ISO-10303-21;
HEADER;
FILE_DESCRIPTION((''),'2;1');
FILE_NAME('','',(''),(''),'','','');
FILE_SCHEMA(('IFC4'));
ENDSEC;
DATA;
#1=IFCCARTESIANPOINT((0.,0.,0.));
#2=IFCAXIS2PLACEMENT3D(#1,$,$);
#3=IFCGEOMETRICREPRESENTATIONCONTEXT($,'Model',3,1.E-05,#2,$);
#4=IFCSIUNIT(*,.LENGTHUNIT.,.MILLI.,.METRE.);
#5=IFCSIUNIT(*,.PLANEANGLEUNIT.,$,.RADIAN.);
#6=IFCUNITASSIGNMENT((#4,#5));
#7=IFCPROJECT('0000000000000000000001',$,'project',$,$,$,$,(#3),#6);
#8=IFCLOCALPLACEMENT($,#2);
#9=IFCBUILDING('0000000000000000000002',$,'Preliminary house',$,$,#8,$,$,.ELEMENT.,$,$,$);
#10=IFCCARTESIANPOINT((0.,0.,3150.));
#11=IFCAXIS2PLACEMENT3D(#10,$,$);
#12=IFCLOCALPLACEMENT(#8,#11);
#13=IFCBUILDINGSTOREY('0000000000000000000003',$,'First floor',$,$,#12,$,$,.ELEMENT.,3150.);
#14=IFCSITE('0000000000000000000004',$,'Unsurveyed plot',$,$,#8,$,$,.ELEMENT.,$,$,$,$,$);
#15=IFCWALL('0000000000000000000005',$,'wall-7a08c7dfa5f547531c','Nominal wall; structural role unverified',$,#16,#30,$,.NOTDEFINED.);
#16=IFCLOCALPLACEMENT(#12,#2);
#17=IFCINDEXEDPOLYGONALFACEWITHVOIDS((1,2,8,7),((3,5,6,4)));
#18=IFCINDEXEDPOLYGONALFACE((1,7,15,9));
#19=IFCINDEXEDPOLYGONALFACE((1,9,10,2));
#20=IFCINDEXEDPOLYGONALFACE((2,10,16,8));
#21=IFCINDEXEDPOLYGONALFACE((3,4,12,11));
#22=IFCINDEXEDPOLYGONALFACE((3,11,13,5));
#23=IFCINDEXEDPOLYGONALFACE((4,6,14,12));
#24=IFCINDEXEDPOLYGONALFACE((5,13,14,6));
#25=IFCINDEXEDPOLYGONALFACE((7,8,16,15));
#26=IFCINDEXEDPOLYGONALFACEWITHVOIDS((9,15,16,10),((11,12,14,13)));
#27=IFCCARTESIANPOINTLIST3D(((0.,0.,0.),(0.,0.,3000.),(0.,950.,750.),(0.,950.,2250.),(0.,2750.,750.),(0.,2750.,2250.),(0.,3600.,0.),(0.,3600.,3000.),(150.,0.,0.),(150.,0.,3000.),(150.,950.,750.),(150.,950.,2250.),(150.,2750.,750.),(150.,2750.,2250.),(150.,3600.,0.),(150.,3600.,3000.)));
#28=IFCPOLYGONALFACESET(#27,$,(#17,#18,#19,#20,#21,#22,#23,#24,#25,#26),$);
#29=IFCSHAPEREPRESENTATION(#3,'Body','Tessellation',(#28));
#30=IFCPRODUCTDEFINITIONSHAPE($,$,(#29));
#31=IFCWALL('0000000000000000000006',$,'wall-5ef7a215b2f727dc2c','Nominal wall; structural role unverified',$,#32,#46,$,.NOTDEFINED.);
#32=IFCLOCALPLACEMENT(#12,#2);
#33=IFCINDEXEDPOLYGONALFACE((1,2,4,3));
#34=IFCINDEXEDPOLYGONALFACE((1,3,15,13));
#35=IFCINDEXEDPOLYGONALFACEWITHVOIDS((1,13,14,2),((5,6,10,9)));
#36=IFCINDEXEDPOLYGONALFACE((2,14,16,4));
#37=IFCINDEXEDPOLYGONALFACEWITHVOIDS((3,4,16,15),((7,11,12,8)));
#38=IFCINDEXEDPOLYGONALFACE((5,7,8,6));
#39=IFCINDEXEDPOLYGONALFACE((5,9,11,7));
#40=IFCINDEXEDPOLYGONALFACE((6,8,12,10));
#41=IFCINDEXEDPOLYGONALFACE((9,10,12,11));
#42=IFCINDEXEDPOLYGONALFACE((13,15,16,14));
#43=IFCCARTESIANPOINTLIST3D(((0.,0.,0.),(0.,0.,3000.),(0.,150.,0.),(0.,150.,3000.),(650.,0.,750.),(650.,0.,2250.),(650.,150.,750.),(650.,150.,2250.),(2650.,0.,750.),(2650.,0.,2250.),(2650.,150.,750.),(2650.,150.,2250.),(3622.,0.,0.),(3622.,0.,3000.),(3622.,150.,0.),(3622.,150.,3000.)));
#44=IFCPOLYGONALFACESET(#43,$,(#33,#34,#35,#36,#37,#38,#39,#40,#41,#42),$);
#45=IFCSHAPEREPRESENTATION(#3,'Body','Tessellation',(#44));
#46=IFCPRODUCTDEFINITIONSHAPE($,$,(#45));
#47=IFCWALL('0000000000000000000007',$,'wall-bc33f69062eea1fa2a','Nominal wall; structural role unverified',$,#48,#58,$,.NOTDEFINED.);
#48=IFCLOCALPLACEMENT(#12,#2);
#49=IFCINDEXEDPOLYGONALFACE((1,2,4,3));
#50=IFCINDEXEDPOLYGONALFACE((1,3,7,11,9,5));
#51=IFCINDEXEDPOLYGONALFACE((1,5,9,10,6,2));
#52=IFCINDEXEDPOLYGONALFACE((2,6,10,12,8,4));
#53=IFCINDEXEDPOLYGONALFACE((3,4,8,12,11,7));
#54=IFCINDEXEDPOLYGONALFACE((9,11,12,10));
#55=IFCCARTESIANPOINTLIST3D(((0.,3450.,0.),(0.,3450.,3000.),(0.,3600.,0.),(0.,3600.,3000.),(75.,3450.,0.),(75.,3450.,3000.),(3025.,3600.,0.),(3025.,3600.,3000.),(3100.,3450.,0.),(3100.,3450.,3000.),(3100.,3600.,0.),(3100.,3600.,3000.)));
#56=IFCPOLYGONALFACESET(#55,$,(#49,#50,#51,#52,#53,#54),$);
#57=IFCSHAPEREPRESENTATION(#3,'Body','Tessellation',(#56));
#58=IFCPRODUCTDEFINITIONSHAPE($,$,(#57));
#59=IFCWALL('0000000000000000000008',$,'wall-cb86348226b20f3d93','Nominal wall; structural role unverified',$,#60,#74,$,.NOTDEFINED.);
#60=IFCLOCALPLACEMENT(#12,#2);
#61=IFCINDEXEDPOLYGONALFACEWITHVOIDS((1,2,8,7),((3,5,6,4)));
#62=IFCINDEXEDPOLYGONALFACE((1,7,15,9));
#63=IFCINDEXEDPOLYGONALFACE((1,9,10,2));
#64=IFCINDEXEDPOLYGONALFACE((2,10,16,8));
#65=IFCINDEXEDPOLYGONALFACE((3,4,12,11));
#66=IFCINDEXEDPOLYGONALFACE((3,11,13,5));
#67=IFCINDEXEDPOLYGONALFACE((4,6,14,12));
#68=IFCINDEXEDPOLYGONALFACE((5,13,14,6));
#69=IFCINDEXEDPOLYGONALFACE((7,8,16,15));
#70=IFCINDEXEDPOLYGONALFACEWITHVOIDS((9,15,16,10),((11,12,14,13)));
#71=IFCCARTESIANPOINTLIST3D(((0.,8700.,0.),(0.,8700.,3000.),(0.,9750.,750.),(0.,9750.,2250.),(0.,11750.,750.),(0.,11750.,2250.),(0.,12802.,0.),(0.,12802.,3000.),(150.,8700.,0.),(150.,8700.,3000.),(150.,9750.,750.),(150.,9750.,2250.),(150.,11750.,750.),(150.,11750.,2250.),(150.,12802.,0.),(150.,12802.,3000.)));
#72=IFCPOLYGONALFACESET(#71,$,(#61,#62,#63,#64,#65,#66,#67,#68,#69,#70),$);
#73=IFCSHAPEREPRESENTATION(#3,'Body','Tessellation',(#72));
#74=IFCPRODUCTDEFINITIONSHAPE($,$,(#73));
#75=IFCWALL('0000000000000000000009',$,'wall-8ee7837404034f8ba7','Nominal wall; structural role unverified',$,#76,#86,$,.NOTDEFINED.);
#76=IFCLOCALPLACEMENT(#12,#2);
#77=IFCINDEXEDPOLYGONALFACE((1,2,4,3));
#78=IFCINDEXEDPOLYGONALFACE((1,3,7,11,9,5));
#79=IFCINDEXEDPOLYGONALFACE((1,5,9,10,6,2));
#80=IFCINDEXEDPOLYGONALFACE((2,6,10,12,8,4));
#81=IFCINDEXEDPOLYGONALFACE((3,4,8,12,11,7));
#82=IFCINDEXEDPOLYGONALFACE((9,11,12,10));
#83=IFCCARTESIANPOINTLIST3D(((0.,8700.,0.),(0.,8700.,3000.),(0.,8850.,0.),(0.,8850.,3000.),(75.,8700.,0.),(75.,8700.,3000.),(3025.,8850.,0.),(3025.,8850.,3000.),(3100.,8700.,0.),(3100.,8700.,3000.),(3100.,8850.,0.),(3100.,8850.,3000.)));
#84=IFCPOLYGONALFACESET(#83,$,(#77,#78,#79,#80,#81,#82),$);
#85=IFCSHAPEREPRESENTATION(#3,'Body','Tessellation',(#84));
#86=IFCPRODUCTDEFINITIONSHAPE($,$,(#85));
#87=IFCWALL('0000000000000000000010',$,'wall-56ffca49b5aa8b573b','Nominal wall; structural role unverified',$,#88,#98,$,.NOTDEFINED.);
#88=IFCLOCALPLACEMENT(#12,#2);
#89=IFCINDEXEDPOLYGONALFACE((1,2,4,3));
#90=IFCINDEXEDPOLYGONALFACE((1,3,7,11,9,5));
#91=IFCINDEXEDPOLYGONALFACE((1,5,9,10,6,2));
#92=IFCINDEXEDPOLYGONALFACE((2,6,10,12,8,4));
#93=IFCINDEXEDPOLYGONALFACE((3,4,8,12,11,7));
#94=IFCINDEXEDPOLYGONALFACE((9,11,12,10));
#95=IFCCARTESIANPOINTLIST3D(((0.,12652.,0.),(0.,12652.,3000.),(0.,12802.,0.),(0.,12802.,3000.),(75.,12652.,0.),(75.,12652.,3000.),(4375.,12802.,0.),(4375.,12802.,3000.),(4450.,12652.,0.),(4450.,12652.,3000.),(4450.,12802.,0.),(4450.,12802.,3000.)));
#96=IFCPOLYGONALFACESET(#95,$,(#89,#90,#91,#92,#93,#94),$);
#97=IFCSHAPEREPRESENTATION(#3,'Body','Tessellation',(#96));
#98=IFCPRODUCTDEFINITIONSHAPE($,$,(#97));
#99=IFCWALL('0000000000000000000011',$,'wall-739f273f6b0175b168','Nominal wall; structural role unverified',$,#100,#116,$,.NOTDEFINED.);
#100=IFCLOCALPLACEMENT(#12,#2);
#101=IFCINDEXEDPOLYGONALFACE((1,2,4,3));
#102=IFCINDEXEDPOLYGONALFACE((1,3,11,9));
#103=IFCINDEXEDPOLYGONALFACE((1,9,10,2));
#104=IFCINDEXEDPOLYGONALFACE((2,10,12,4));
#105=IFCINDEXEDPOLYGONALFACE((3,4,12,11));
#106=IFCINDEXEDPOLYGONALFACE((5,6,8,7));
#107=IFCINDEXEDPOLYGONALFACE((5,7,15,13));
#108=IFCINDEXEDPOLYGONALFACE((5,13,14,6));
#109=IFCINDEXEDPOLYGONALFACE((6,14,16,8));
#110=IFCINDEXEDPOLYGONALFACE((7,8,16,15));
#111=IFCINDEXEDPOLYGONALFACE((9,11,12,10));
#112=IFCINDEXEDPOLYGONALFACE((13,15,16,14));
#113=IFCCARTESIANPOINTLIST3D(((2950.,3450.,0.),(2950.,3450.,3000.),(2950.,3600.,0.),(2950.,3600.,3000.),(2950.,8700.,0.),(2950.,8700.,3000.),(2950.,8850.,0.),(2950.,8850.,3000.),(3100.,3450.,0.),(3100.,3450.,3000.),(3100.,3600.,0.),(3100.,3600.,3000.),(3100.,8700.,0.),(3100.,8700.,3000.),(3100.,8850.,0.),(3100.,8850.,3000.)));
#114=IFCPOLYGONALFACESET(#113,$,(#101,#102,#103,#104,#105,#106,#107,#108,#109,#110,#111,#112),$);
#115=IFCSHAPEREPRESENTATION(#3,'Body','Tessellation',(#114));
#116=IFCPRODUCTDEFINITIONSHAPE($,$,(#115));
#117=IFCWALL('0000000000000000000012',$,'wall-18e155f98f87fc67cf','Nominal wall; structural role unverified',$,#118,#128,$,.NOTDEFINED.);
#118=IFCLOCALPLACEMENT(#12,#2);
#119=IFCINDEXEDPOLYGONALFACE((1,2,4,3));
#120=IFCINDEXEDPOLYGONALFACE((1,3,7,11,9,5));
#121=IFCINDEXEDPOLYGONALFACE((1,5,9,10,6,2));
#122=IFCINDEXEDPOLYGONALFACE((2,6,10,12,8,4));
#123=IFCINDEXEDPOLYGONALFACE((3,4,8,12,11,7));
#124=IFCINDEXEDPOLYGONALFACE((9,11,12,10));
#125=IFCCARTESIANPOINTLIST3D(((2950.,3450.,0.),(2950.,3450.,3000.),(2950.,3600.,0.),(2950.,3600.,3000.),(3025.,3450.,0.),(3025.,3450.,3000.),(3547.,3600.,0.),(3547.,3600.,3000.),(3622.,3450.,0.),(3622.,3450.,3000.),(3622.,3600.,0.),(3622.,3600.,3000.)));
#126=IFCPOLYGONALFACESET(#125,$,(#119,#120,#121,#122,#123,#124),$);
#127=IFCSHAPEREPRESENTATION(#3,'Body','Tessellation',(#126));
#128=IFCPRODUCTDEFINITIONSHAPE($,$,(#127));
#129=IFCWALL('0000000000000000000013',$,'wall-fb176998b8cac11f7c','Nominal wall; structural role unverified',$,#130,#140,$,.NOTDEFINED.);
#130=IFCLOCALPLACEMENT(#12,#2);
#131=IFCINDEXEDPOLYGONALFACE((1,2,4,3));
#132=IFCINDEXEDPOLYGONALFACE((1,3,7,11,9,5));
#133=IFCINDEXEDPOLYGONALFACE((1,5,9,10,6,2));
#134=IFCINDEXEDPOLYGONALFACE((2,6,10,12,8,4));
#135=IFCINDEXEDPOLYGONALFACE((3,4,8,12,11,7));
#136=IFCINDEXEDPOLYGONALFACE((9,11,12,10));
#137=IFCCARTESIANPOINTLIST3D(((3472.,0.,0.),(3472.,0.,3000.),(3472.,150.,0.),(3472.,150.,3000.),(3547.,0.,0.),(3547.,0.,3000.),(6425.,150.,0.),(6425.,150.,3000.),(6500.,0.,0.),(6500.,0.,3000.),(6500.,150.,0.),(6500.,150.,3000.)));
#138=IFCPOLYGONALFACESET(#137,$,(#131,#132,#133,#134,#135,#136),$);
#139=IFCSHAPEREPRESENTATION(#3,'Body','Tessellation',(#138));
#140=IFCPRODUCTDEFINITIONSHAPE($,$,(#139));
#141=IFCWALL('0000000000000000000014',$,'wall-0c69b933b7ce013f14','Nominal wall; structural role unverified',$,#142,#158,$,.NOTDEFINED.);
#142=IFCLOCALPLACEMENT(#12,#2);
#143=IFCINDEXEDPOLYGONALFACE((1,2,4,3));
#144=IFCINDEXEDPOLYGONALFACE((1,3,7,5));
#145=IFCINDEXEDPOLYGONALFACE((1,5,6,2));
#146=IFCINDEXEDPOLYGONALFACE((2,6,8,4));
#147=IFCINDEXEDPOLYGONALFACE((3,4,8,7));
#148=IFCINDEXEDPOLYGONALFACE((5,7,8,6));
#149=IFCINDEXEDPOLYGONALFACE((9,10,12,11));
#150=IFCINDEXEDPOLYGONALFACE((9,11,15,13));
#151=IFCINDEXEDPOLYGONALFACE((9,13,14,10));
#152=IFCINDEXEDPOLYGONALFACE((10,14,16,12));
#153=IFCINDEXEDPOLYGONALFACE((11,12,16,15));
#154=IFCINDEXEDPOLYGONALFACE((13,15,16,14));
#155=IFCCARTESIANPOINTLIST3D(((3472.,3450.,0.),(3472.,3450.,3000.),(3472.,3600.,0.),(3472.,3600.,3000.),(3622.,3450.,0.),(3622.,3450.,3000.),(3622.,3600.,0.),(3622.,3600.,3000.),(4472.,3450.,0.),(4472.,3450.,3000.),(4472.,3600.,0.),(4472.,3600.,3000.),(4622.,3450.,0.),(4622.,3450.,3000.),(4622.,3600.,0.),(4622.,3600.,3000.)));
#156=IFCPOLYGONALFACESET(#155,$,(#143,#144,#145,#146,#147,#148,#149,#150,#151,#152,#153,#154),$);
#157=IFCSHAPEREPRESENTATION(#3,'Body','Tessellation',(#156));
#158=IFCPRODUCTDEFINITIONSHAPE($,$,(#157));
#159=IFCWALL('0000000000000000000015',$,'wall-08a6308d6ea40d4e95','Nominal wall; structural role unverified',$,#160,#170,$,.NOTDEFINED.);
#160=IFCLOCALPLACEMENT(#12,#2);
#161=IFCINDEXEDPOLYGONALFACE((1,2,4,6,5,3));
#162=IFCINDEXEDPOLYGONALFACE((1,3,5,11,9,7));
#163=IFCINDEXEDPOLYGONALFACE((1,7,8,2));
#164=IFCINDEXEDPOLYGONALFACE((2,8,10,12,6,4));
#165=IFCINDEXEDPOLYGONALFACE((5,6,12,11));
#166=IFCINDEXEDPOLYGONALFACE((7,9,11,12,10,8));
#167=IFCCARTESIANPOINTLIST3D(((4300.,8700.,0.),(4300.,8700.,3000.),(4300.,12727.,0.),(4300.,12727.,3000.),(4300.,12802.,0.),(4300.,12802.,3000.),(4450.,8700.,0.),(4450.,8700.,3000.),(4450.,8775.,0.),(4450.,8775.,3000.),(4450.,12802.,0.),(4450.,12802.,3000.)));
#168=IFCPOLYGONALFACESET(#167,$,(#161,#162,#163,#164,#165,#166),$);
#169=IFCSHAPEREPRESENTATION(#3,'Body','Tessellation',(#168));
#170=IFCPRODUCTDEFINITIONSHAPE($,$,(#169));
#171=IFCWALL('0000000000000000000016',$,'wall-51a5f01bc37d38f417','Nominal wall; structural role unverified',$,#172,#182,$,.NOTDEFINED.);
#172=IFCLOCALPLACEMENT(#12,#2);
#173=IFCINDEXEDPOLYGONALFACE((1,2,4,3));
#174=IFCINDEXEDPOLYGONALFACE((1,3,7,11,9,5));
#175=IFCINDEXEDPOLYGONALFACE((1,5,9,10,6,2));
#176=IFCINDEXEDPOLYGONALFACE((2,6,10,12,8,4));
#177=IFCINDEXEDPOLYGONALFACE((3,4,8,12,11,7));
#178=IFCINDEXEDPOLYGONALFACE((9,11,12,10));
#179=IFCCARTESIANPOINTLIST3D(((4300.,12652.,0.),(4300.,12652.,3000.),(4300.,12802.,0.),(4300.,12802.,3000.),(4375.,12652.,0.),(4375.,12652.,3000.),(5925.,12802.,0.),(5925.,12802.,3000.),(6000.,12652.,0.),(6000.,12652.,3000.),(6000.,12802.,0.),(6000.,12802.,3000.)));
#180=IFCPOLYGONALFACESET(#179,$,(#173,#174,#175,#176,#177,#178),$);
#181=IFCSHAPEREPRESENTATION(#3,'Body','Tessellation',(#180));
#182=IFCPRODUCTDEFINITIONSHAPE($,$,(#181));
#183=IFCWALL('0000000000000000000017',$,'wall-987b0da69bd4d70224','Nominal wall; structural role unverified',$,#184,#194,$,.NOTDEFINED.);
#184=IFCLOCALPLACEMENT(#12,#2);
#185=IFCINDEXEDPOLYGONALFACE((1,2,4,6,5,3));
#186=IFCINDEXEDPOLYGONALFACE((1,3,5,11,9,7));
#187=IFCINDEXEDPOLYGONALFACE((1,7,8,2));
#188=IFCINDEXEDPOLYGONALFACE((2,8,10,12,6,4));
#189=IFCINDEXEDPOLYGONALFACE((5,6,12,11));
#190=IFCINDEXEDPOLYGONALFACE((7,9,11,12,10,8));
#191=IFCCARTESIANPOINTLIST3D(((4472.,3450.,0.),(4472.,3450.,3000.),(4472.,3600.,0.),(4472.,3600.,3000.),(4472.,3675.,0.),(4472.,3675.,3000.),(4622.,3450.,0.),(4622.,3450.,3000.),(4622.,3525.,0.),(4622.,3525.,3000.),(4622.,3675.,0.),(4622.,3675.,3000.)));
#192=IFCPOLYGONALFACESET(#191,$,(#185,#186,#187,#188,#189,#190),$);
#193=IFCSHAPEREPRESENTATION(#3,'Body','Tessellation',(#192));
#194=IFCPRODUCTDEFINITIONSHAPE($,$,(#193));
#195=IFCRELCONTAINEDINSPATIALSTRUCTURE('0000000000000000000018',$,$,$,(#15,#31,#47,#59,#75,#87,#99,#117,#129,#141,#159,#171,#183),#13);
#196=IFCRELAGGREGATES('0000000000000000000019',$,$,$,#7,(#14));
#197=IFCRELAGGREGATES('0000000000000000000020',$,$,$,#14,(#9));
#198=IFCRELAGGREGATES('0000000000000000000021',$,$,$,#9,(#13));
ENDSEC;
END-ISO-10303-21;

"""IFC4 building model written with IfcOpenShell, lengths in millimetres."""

from ifc_helpers import new_model, si_unit, frame, origin, place, context, project, spatial, polyline, outline, extrude, element, save


model = new_model("IFC4")

# Units and contexts
model_context = context("Model", 3, precision=1e-05, world=origin())
ifc_project = project(units=[si_unit("LENGTHUNIT", "METRE", prefix="MILLI"), si_unit("PLANEANGLEUNIT", "RADIAN")], contexts=[model_context])

# Site, building, storey
placement_1 = place(None, origin())
site = spatial("IfcSite", under=ifc_project, at=placement_1, Name="Unsurveyed plot", CompositionType="ELEMENT")
building = spatial("IfcBuilding", under=site, at=placement_1, Name="Preliminary house", CompositionType="ELEMENT")
placement_2 = place(placement_1, frame((0.0, 0.0, 3150.0)))
storey = spatial("IfcBuildingStorey", under=building, at=placement_2, Name="First floor", CompositionType="ELEMENT", Elevation=3150.0)

# Walls, openings
wall_1 = element("IfcWall", 1, at=placement_2, inside=storey, Name="wall-7a08c7dfa5f547531c", Description="Nominal wall; structural role unverified", PredefinedType="NOTDEFINED", context=model_context, shape_type="SweptSolid", body=[
    extrude(outline(polyline([(0.0, 3525.0), (0.0, 3600.0), (150.0, 3600.0), (150.0, 75.0), (150.0, 0.0), (0.0, 0.0), (0.0, 3525.0)])), origin(), (0.0, 0.0, 1.0), 3000.0),
])
element("IfcOpeningElement", 2, at=placement_2, cuts=wall_1, PredefinedType="OPENING", context=model_context, shape_type="SweptSolid", body=[
    extrude(outline(polyline([(525.0, 950.0), (525.0, 2750.0), (-375.0, 2750.0), (-375.0, 950.0), (525.0, 950.0)])), frame((0.0, 0.0, 750.0)), (0.0, 0.0, 1.0), 1500.0),
])
wall_2 = element("IfcWall", 3, at=placement_2, inside=storey, Name="wall-5ef7a215b2f727dc2c", Description="Nominal wall; structural role unverified", PredefinedType="NOTDEFINED", context=model_context, shape_type="SweptSolid", body=[
    extrude(outline(polyline([(3547.0, 150.0), (3622.0, 150.0), (3622.0, 0.0), (75.0, 0.0), (0.0, 0.0), (0.0, 150.0), (3547.0, 150.0)])), origin(), (0.0, 0.0, 1.0), 3000.0),
])
element("IfcOpeningElement", 4, at=placement_2, cuts=wall_2, PredefinedType="OPENING", context=model_context, shape_type="SweptSolid", body=[
    extrude(outline(polyline([(650.0, -375.0), (2650.0, -375.0), (2650.0, 525.0), (650.0, 525.0), (650.0, -375.0)])), frame((0.0, 0.0, 750.0)), (0.0, 0.0, 1.0), 1500.0),
])

# Wall
element("IfcWall", 5, at=placement_2, inside=storey, Name="wall-bc33f69062eea1fa2a", Description="Nominal wall; structural role unverified", PredefinedType="NOTDEFINED", context=model_context, shape_type="SweptSolid", body=[
    extrude(outline(polyline([(3025.0, 3600.0), (3100.0, 3600.0), (3100.0, 3450.0), (75.0, 3450.0), (0.0, 3450.0), (0.0, 3600.0), (3025.0, 3600.0)])), origin(), (0.0, 0.0, 1.0), 3000.0),
])

# Wall, opening
wall_3 = element("IfcWall", 6, at=placement_2, inside=storey, Name="wall-cb86348226b20f3d93", Description="Nominal wall; structural role unverified", PredefinedType="NOTDEFINED", context=model_context, shape_type="SweptSolid", body=[
    extrude(outline(polyline([(0.0, 12727.0), (0.0, 12802.0), (150.0, 12802.0), (150.0, 8775.0), (150.0, 8700.0), (0.0, 8700.0), (0.0, 12727.0)])), origin(), (0.0, 0.0, 1.0), 3000.0),
])
element("IfcOpeningElement", 7, at=placement_2, cuts=wall_3, PredefinedType="OPENING", context=model_context, shape_type="SweptSolid", body=[
    extrude(outline(polyline([(525.0, 9750.0), (525.0, 11750.0), (-375.0, 11750.0), (-375.0, 9750.0), (525.0, 9750.0)])), frame((0.0, 0.0, 750.0)), (0.0, 0.0, 1.0), 1500.0),
])

# Walls
element("IfcWall", 8, at=placement_2, inside=storey, Name="wall-8ee7837404034f8ba7", Description="Nominal wall; structural role unverified", PredefinedType="NOTDEFINED", context=model_context, shape_type="SweptSolid", body=[
    extrude(outline(polyline([(3025.0, 8850.0), (3100.0, 8850.0), (3100.0, 8700.0), (75.0, 8700.0), (0.0, 8700.0), (0.0, 8850.0), (3025.0, 8850.0)])), origin(), (0.0, 0.0, 1.0), 3000.0),
])
element("IfcWall", 9, at=placement_2, inside=storey, Name="wall-56ffca49b5aa8b573b", Description="Nominal wall; structural role unverified", PredefinedType="NOTDEFINED", context=model_context, shape_type="SweptSolid", body=[
    extrude(outline(polyline([(4375.0, 12802.0), (4450.0, 12802.0), (4450.0, 12652.0), (75.0, 12652.0), (0.0, 12652.0), (0.0, 12802.0), (4375.0, 12802.0)])), origin(), (0.0, 0.0, 1.0), 3000.0),
])

# Wall, opening
wall_4 = element("IfcWall", 10, at=placement_2, inside=storey, Name="wall-739f273f6b0175b168", Description="Nominal wall; structural role unverified", PredefinedType="NOTDEFINED", context=model_context, shape_type="SweptSolid", body=[
    extrude(outline(polyline([(2950.0, 8775.0), (2950.0, 8850.0), (3100.0, 8850.0), (3100.0, 3525.0), (3100.0, 3450.0), (2950.0, 3450.0), (2950.0, 8775.0)])), origin(), (0.0, 0.0, 1.0), 3000.0),
])
element("IfcOpeningElement", 11, at=placement_2, cuts=wall_4, PredefinedType="OPENING", context=model_context, shape_type="SweptSolid", body=[
    extrude(outline(polyline([(3475.0, 3600.0), (3475.0, 8700.0), (2575.0, 8700.0), (2575.0, 3600.0), (3475.0, 3600.0)])), origin(), (0.0, 0.0, 1.0), 3000.0),
])

# Wall
element("IfcWall", 12, at=placement_2, inside=storey, Name="wall-18e155f98f87fc67cf", Description="Nominal wall; structural role unverified", PredefinedType="NOTDEFINED", context=model_context, shape_type="SweptSolid", body=[
    extrude(outline(polyline([(3547.0, 3600.0), (3622.0, 3600.0), (3622.0, 3450.0), (3025.0, 3450.0), (2950.0, 3450.0), (2950.0, 3600.0), (3547.0, 3600.0)])), origin(), (0.0, 0.0, 1.0), 3000.0),
])

# Wall
element("IfcWall", 13, at=placement_2, inside=storey, Name="wall-fb176998b8cac11f7c", Description="Nominal wall; structural role unverified", PredefinedType="NOTDEFINED", context=model_context, shape_type="SweptSolid", body=[
    extrude(outline(polyline([(6425.0, 150.0), (6500.0, 150.0), (6500.0, 0.0), (3547.0, 0.0), (3472.0, 0.0), (3472.0, 150.0), (6425.0, 150.0)])), origin(), (0.0, 0.0, 1.0), 3000.0),
])

# Wall, opening
wall_5 = element("IfcWall", 14, at=placement_2, inside=storey, Name="wall-0c69b933b7ce013f14", Description="Nominal wall; structural role unverified", PredefinedType="NOTDEFINED", context=model_context, shape_type="SweptSolid", body=[
    extrude(outline(polyline([(4547.0, 3600.0), (4622.0, 3600.0), (4622.0, 3450.0), (3547.0, 3450.0), (3472.0, 3450.0), (3472.0, 3600.0), (4547.0, 3600.0)])), origin(), (0.0, 0.0, 1.0), 3000.0),
])
element("IfcOpeningElement", 15, at=placement_2, cuts=wall_5, PredefinedType="OPENING", context=model_context, shape_type="SweptSolid", body=[
    extrude(outline(polyline([(3622.0, 3075.0), (4472.0, 3075.0), (4472.0, 3975.0), (3622.0, 3975.0), (3622.0, 3075.0)])), origin(), (0.0, 0.0, 1.0), 3000.0),
])

# Wall
element("IfcWall", 16, at=placement_2, inside=storey, Name="wall-08a6308d6ea40d4e95", Description="Nominal wall; structural role unverified", PredefinedType="NOTDEFINED", context=model_context, shape_type="SweptSolid", body=[
    extrude(outline(polyline([(4300.0, 12727.0), (4300.0, 12802.0), (4450.0, 12802.0), (4450.0, 8775.0), (4450.0, 8700.0), (4300.0, 8700.0), (4300.0, 12727.0)])), origin(), (0.0, 0.0, 1.0), 3000.0),
])

# Walls
element("IfcWall", 17, at=placement_2, inside=storey, Name="wall-51a5f01bc37d38f417", Description="Nominal wall; structural role unverified", PredefinedType="NOTDEFINED", context=model_context, shape_type="SweptSolid", body=[
    extrude(outline(polyline([(5925.0, 12802.0), (6000.0, 12802.0), (6000.0, 12652.0), (4375.0, 12652.0), (4300.0, 12652.0), (4300.0, 12802.0), (5925.0, 12802.0)])), origin(), (0.0, 0.0, 1.0), 3000.0),
])
element("IfcWall", 18, at=placement_2, inside=storey, Name="wall-987b0da69bd4d70224", Description="Nominal wall; structural role unverified", PredefinedType="NOTDEFINED", context=model_context, shape_type="SweptSolid", body=[
    extrude(outline(polyline([(4472.0, 3600.0), (4472.0, 3675.0), (4622.0, 3675.0), (4622.0, 3525.0), (4622.0, 3450.0), (4472.0, 3450.0), (4472.0, 3600.0)])), origin(), (0.0, 0.0, 1.0), 3000.0),
])

save(model, "model.ifc")
